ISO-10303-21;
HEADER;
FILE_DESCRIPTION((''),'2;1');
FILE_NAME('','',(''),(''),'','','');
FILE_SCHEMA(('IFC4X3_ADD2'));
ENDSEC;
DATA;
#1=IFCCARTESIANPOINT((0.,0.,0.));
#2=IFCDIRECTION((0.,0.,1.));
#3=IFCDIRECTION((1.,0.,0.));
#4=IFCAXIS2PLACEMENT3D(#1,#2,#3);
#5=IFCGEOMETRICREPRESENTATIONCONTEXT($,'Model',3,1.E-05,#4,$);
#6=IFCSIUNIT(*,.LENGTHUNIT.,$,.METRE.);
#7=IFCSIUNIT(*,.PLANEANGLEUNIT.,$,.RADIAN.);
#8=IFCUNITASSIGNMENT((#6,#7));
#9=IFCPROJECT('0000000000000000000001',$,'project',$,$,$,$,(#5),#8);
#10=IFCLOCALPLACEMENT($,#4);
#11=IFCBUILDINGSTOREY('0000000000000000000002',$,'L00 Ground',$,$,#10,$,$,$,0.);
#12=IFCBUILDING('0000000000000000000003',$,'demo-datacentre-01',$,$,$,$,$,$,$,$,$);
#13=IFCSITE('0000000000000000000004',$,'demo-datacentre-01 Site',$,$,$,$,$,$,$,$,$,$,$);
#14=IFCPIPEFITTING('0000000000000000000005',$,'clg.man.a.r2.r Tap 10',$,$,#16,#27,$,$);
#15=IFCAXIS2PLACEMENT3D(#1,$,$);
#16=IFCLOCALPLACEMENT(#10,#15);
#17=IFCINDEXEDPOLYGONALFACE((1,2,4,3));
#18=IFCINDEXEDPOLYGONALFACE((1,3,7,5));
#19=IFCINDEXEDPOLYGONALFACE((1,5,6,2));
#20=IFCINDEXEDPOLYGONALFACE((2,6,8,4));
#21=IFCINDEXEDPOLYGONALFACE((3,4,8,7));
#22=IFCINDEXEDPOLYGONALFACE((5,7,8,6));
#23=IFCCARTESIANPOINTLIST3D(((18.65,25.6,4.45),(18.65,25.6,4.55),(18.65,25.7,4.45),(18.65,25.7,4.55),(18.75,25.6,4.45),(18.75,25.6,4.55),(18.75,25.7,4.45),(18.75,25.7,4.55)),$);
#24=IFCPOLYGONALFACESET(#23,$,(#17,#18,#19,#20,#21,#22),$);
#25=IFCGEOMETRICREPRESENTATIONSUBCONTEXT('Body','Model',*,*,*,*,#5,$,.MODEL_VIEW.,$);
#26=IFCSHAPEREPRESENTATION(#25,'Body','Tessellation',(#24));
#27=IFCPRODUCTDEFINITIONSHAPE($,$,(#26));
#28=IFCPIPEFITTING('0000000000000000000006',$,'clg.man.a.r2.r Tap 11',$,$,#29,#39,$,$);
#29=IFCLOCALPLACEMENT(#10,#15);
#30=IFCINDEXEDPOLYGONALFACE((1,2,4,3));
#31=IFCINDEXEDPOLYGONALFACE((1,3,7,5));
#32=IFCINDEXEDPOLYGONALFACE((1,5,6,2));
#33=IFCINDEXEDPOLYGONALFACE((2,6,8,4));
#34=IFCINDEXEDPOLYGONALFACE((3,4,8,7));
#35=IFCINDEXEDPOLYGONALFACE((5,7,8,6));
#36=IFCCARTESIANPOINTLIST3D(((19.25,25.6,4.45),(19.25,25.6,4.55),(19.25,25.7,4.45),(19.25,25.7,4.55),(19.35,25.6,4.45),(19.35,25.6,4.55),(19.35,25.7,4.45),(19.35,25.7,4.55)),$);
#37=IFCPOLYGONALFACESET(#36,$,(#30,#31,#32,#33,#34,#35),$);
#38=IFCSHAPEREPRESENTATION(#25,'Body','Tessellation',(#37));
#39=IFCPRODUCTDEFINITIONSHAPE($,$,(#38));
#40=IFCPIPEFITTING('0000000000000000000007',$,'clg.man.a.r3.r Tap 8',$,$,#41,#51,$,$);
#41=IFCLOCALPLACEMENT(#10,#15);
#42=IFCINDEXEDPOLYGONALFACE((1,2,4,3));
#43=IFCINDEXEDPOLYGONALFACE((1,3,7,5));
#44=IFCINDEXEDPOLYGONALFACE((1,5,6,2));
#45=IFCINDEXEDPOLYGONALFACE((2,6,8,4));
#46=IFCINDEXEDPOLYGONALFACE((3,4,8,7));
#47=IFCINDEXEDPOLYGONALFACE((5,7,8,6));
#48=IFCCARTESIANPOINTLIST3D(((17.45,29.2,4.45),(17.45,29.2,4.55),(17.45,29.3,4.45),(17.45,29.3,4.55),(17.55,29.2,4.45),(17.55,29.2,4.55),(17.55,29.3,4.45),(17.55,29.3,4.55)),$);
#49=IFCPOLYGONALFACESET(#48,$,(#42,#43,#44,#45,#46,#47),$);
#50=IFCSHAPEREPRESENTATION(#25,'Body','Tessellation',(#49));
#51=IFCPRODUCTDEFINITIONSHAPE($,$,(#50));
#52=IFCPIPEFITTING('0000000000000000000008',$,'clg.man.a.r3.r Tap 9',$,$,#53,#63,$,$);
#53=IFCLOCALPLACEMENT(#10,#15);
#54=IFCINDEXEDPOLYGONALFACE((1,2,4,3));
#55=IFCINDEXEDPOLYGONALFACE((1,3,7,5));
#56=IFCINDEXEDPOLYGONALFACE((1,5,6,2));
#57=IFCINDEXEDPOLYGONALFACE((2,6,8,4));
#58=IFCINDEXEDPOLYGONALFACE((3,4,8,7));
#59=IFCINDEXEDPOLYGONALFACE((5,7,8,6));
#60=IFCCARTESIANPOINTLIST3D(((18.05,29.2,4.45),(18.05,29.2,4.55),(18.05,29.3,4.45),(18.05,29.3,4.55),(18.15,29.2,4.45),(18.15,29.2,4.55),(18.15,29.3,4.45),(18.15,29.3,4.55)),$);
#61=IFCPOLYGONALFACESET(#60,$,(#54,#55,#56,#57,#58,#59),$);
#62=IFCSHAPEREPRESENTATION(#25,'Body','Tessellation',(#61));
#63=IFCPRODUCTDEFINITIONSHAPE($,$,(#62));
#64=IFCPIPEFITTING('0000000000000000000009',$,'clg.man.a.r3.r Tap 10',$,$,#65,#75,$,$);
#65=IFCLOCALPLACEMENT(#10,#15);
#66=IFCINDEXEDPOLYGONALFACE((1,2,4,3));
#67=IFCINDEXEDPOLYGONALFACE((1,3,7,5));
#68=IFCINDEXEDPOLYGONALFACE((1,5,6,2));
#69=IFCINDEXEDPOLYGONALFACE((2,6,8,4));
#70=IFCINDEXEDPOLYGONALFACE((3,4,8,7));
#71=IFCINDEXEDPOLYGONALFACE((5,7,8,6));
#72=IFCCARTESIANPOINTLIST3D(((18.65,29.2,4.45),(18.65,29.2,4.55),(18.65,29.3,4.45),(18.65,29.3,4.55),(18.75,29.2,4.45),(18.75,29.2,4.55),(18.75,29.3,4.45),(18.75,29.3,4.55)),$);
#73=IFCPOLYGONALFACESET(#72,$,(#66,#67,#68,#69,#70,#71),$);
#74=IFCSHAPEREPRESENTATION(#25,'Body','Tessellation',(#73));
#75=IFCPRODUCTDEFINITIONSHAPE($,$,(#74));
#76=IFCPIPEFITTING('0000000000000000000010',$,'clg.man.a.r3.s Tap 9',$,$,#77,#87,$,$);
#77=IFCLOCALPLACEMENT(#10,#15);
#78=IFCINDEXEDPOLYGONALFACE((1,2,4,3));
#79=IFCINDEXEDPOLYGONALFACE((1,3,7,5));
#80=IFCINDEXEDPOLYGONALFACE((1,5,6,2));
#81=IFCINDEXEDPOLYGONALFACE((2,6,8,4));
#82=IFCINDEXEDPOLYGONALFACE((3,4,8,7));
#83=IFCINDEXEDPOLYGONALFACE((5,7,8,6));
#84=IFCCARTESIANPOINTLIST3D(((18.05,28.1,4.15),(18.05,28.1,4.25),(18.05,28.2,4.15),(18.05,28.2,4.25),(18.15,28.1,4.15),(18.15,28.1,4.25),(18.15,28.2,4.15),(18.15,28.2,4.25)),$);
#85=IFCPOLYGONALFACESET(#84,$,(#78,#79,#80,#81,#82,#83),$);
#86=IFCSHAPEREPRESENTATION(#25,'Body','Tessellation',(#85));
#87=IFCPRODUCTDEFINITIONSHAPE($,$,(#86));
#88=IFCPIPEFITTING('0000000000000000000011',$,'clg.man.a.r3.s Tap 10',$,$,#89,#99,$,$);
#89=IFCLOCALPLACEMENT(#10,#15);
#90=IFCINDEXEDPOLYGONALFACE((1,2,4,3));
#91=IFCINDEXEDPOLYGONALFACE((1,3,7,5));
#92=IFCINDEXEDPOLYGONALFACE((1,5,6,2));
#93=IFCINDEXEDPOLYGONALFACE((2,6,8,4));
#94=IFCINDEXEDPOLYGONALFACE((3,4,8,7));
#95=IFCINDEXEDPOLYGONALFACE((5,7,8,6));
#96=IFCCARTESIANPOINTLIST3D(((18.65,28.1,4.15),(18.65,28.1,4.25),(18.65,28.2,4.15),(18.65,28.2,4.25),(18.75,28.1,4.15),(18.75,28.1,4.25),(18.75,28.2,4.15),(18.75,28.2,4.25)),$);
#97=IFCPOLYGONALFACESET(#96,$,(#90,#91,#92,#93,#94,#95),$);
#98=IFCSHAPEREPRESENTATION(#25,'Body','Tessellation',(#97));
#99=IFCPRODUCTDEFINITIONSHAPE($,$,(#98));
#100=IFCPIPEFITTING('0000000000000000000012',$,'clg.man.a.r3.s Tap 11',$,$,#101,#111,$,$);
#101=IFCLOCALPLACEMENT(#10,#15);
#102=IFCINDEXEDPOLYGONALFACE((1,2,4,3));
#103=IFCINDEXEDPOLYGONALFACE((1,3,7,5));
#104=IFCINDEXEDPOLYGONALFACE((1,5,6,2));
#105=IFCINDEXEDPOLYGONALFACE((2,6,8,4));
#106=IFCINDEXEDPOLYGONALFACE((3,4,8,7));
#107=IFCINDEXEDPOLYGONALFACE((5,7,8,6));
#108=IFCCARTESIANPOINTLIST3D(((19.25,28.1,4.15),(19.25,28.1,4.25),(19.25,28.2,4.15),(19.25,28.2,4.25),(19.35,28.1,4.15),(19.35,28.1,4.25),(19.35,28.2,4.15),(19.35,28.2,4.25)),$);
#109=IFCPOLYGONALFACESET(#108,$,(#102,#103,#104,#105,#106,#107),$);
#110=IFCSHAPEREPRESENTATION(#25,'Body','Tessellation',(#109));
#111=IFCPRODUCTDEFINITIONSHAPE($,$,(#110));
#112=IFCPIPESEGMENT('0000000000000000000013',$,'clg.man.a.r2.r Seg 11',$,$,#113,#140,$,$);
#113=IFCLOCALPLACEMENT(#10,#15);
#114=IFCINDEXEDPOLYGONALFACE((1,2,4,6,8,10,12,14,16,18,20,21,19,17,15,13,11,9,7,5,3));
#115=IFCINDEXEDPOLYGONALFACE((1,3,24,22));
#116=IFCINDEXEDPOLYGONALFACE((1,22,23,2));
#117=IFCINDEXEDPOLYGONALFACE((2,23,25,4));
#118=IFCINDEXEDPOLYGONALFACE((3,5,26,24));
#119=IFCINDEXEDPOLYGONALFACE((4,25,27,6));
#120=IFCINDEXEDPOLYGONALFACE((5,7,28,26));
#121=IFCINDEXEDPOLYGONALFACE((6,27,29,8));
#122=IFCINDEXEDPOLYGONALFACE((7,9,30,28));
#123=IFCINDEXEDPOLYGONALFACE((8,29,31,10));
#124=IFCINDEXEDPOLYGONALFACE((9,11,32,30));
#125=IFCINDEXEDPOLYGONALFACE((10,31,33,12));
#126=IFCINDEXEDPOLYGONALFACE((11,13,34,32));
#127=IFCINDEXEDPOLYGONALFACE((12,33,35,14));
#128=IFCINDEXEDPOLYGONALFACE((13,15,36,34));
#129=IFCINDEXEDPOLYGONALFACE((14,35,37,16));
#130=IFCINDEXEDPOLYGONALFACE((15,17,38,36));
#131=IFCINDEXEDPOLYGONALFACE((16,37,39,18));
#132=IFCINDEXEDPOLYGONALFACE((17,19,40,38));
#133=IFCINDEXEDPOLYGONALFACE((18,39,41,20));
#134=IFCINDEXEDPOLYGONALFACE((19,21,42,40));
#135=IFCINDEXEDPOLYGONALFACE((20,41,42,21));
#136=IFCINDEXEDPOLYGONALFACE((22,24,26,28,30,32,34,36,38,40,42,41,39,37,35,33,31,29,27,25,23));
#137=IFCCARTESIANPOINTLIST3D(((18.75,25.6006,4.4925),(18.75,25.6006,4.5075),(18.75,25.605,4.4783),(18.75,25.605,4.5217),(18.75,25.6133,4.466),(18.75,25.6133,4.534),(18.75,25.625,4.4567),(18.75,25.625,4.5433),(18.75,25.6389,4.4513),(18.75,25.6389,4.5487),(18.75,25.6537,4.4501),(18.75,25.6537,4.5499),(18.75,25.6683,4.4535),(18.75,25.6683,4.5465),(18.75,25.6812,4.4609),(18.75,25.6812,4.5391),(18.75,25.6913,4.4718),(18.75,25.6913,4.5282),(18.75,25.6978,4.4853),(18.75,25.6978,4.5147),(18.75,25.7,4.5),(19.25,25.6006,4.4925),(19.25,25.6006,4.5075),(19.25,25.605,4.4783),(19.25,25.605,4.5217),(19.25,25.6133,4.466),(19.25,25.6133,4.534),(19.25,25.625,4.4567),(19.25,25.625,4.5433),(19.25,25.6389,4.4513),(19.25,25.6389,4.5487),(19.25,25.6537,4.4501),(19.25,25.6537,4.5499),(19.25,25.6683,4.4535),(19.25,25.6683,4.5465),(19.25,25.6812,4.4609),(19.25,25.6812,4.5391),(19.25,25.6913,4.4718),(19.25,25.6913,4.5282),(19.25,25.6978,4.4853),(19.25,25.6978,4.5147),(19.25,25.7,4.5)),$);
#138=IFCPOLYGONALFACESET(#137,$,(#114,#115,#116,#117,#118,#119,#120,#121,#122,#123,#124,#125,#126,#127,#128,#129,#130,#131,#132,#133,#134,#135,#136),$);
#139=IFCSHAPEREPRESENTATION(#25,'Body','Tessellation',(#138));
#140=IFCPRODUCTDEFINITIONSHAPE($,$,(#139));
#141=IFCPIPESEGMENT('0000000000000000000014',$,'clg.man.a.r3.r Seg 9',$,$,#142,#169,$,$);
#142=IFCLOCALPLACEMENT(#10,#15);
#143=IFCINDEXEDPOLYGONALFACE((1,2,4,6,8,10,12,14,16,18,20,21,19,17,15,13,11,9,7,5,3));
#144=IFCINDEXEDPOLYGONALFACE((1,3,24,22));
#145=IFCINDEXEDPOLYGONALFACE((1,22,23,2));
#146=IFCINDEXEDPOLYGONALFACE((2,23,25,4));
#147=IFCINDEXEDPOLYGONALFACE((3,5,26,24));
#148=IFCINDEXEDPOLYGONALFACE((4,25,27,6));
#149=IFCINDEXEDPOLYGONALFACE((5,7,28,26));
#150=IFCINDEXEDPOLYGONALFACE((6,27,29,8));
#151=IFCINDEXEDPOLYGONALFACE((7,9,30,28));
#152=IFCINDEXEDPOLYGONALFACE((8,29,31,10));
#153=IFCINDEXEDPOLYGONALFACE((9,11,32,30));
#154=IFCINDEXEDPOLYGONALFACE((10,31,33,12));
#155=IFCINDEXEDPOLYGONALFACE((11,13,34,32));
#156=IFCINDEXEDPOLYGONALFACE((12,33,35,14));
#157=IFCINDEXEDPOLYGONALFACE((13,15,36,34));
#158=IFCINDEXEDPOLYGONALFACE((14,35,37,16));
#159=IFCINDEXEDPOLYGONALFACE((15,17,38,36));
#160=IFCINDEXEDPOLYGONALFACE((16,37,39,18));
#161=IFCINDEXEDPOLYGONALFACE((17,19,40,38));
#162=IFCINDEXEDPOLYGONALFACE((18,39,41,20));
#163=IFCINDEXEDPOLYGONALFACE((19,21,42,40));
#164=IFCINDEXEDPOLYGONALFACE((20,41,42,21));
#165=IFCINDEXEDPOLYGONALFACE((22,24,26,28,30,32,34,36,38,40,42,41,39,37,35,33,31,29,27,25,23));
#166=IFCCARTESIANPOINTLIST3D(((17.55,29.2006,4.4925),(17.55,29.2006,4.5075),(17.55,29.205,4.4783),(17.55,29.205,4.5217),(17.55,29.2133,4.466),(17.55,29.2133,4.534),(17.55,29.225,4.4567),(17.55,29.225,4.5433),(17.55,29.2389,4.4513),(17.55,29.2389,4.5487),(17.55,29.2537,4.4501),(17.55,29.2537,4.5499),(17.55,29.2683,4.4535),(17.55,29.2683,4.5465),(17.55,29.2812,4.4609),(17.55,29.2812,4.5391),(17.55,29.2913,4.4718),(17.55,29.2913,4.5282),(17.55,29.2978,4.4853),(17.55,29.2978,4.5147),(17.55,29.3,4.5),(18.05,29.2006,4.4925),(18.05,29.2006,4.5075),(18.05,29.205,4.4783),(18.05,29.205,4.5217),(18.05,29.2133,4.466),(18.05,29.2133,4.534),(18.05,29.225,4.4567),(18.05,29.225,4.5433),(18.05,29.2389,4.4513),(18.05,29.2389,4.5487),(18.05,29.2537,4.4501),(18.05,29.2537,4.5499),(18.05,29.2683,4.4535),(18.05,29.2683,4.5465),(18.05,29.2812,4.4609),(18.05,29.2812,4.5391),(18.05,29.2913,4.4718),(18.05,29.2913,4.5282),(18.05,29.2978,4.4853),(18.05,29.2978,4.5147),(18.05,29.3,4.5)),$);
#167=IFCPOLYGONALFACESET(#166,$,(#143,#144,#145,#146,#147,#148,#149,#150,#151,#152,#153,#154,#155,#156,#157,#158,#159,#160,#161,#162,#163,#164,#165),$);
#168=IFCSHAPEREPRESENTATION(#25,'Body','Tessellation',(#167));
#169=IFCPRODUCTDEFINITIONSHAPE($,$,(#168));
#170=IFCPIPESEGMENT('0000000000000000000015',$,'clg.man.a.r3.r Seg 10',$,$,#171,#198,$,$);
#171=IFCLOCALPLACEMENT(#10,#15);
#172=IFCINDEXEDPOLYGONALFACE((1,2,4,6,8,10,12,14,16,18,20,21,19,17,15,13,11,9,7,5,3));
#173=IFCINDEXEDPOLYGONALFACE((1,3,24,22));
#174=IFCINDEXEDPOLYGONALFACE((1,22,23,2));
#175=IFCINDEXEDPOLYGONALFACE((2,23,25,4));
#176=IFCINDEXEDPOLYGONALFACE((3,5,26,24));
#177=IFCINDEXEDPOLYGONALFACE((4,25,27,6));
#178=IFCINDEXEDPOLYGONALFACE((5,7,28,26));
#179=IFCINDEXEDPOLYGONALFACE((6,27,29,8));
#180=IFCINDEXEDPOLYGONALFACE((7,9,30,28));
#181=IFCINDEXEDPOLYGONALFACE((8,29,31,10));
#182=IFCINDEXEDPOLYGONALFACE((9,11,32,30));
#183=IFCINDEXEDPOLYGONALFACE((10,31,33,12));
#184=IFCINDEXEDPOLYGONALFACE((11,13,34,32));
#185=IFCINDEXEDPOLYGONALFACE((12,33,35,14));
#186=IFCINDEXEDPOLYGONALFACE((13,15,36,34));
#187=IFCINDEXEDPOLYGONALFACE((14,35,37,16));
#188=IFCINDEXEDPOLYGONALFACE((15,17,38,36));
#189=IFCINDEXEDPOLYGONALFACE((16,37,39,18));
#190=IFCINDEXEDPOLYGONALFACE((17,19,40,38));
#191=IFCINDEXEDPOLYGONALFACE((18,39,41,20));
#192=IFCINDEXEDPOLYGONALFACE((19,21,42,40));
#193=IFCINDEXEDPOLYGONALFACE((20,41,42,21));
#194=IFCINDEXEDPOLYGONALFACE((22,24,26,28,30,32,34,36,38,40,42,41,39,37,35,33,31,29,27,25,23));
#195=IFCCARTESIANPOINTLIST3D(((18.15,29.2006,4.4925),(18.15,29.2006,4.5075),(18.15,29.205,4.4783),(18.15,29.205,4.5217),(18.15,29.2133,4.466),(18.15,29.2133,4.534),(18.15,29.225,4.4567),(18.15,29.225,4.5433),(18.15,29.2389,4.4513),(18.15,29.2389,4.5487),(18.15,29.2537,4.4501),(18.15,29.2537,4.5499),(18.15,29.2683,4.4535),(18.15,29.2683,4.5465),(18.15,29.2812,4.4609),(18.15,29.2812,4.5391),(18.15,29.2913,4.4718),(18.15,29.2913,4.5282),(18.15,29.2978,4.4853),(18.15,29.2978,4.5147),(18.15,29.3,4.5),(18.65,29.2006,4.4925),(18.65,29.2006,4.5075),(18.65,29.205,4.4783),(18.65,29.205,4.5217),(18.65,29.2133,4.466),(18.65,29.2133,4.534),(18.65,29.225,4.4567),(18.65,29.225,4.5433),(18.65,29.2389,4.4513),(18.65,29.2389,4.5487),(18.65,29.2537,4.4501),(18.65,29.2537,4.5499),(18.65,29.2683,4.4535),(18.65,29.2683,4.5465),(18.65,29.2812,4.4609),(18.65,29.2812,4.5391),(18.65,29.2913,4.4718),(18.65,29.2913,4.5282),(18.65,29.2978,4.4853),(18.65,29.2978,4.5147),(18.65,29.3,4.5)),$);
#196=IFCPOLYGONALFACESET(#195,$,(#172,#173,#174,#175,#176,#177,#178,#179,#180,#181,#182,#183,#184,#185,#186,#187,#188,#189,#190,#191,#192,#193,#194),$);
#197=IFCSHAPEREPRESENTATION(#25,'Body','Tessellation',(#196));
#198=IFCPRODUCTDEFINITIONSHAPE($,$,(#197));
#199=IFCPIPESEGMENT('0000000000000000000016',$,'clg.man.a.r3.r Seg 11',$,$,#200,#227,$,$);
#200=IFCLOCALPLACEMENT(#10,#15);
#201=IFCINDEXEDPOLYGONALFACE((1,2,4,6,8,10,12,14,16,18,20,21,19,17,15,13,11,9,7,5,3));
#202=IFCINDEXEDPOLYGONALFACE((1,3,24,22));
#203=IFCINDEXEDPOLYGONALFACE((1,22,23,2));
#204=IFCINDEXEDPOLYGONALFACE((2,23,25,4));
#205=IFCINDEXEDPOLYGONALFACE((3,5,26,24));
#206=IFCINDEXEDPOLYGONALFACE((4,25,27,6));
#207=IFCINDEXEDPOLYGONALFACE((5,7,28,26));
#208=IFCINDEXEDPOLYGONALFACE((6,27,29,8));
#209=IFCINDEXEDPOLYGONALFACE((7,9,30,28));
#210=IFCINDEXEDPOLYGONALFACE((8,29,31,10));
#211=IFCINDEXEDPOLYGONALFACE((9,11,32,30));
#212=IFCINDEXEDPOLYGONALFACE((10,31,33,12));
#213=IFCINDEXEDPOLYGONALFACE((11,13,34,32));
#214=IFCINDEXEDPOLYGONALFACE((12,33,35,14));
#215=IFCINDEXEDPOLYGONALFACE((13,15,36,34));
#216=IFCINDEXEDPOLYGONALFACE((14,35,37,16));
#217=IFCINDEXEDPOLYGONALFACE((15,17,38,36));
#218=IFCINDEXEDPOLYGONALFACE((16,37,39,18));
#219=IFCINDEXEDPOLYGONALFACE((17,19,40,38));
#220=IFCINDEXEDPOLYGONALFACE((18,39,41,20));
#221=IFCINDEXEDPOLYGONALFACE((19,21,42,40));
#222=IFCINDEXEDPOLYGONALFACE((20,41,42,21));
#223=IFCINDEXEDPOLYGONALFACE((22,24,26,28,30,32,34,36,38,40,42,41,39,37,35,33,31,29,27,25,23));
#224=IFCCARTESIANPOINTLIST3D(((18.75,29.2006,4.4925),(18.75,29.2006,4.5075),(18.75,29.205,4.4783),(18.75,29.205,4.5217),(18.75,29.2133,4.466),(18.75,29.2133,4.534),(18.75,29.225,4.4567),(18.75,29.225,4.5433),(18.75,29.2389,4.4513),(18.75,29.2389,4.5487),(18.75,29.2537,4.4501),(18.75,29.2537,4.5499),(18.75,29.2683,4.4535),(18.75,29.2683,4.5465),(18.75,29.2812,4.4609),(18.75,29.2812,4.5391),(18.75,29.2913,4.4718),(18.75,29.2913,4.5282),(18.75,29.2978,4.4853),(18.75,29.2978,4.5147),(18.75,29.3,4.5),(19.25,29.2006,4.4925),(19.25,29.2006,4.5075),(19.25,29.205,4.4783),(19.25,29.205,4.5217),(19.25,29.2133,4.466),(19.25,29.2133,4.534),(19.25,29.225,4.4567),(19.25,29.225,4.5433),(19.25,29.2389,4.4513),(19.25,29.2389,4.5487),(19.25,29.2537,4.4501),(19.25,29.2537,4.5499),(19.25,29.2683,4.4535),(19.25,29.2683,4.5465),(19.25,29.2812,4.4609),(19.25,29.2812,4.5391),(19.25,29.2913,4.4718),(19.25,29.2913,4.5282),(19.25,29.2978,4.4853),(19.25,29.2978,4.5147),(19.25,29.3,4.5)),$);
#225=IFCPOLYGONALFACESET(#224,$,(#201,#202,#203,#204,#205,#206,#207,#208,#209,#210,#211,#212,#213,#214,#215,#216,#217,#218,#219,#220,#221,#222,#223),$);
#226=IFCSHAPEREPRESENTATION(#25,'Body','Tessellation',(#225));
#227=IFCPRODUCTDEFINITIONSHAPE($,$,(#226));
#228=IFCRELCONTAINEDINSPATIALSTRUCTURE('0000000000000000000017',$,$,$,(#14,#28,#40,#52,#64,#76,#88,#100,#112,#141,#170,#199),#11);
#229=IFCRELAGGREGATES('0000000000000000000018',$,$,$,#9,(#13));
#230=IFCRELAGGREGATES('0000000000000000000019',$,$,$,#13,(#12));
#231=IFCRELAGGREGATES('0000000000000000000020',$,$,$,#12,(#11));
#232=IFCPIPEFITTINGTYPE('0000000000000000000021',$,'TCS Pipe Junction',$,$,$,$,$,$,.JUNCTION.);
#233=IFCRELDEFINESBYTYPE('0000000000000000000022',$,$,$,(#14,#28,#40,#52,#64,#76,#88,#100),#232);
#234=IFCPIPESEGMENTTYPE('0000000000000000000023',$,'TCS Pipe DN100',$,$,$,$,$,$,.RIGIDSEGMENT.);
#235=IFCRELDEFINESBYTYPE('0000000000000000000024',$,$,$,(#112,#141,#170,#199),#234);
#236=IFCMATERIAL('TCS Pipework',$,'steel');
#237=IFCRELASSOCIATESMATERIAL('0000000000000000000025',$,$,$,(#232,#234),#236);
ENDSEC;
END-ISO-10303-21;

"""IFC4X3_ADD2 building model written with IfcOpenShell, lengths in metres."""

from ifc_helpers import new_model, si_unit, frame, origin_with_axes, place, context, subcontext, project, spatial, rectangle, circle, extrude, material, type_object, element, save


model = new_model("IFC4X3_ADD2")

# Units and contexts
model_context = context("Model", 3, precision=1e-05, world=origin_with_axes())
body_context = subcontext(model_context, "Body", "Model", "MODEL_VIEW")
ifc_project = project(units=[si_unit("LENGTHUNIT", "METRE"), si_unit("PLANEANGLEUNIT", "RADIAN")], contexts=[model_context])

# Site, building, storey
site = spatial("IfcSite", under=ifc_project, Name="demo-datacentre-01 Site")
building = spatial("IfcBuilding", under=site, Name="demo-datacentre-01")
storey_placement = place(None, origin_with_axes())
storey = spatial("IfcBuildingStorey", under=building, at=storey_placement, Name="L00 Ground", Elevation=0.0)

# Pipe fittings
ifc_material = material(Name="TCS Pipework", Category="steel")
pipe_fitting_type = type_object("IfcPipeFittingType", Name="TCS Pipe Junction", PredefinedType="JUNCTION", material=ifc_material)
for number, where, z_axis, x_axis, name in (
    (1, (18.7, 25.65, 4.45), (0.0, 0.0, 1.0), (1.0, 0.0, 0.0), "clg.man.a.r2.r Tap 10"),
    (2, (19.3, 25.65, 4.45), (0.0, 0.0, 1.0), (1.0, 0.0, 0.0), "clg.man.a.r2.r Tap 11"),
    (3, (17.5, 29.25, 4.45), (0.0, 0.0, 1.0), (1.0, 0.0, 0.0), "clg.man.a.r3.r Tap 8"),
    (4, (18.1, 29.25, 4.45), (0.0, 0.0, 1.0), (1.0, 0.0, 0.0), "clg.man.a.r3.r Tap 9"),
    (5, (18.7, 29.25, 4.45), (0.0, 0.0, 1.0), (1.0, 0.0, 0.0), "clg.man.a.r3.r Tap 10"),
    (6, (18.1, 28.15, 4.15), (0.0, 0.0, 1.0), (1.0, 0.0, 0.0), "clg.man.a.r3.s Tap 9"),
    (7, (18.7, 28.15, 4.15), (0.0, 0.0, 1.0), (1.0, 0.0, 0.0), "clg.man.a.r3.s Tap 10"),
    (8, (19.3, 28.15, 4.15), (0.0, 0.0, 1.0), (1.0, 0.0, 0.0), "clg.man.a.r3.s Tap 11"),
):
    element("IfcPipeFitting", number, at=place(storey_placement, frame(where, z_axis=z_axis, x_axis=x_axis)), inside=storey, type_object=pipe_fitting_type, Name=name, context=body_context, shape_type="SweptSolid", body=[
        extrude(rectangle(XDim=0.1, YDim=0.1), origin_with_axes(), (0.0, 0.0, 1.0), 0.1),
    ])

# Pipe segments
pipe_segment_type_1 = type_object("IfcPipeSegmentType", Name="TCS Pipe DN100", PredefinedType="RIGIDSEGMENT", material=ifc_material)
for number, where, z_axis, x_axis, name in (
    (9, (18.75, 25.65, 4.5), (1.0, 0.0, 0.0), (0.0, 1.0, 0.0), "clg.man.a.r2.r Seg 11"),
    (10, (17.55, 29.25, 4.5), (1.0, 0.0, 0.0), (0.0, 1.0, 0.0), "clg.man.a.r3.r Seg 9"),
):
    element("IfcPipeSegment", number, at=place(storey_placement, frame(where, z_axis=z_axis, x_axis=x_axis)), inside=storey, type_object=pipe_segment_type_1, Name=name, context=body_context, shape_type="SweptSolid", body=[
        extrude(circle(Radius=0.05), origin_with_axes(), (0.0, 0.0, 1.0), 0.5),
    ])
pipe_segment_1_placement = place(storey_placement, frame((18.15, 29.25, 4.5), z_axis=(1.0, 0.0, 0.0), x_axis=(0.0, 1.0, 0.0)))
element("IfcPipeSegment", 11, at=pipe_segment_1_placement, inside=storey, type_object=pipe_segment_type_1, Name="clg.man.a.r3.r Seg 10", context=body_context, shape_type="SweptSolid", body=[
    extrude(circle(Radius=0.05), origin_with_axes(), (0.0, 0.0, 1.0), 0.5),
])
for number, where, z_axis, x_axis, name in (
    (12, (18.75, 29.25, 4.5), (1.0, 0.0, 0.0), (0.0, 1.0, 0.0), "clg.man.a.r3.r Seg 11"),
):
    element("IfcPipeSegment", number, at=place(storey_placement, frame(where, z_axis=z_axis, x_axis=x_axis)), inside=storey, type_object=pipe_segment_type_1, Name=name, context=body_context, shape_type="SweptSolid", body=[
        extrude(circle(Radius=0.05), origin_with_axes(), (0.0, 0.0, 1.0), 0.5),
    ])

save(model, "model.ifc")
